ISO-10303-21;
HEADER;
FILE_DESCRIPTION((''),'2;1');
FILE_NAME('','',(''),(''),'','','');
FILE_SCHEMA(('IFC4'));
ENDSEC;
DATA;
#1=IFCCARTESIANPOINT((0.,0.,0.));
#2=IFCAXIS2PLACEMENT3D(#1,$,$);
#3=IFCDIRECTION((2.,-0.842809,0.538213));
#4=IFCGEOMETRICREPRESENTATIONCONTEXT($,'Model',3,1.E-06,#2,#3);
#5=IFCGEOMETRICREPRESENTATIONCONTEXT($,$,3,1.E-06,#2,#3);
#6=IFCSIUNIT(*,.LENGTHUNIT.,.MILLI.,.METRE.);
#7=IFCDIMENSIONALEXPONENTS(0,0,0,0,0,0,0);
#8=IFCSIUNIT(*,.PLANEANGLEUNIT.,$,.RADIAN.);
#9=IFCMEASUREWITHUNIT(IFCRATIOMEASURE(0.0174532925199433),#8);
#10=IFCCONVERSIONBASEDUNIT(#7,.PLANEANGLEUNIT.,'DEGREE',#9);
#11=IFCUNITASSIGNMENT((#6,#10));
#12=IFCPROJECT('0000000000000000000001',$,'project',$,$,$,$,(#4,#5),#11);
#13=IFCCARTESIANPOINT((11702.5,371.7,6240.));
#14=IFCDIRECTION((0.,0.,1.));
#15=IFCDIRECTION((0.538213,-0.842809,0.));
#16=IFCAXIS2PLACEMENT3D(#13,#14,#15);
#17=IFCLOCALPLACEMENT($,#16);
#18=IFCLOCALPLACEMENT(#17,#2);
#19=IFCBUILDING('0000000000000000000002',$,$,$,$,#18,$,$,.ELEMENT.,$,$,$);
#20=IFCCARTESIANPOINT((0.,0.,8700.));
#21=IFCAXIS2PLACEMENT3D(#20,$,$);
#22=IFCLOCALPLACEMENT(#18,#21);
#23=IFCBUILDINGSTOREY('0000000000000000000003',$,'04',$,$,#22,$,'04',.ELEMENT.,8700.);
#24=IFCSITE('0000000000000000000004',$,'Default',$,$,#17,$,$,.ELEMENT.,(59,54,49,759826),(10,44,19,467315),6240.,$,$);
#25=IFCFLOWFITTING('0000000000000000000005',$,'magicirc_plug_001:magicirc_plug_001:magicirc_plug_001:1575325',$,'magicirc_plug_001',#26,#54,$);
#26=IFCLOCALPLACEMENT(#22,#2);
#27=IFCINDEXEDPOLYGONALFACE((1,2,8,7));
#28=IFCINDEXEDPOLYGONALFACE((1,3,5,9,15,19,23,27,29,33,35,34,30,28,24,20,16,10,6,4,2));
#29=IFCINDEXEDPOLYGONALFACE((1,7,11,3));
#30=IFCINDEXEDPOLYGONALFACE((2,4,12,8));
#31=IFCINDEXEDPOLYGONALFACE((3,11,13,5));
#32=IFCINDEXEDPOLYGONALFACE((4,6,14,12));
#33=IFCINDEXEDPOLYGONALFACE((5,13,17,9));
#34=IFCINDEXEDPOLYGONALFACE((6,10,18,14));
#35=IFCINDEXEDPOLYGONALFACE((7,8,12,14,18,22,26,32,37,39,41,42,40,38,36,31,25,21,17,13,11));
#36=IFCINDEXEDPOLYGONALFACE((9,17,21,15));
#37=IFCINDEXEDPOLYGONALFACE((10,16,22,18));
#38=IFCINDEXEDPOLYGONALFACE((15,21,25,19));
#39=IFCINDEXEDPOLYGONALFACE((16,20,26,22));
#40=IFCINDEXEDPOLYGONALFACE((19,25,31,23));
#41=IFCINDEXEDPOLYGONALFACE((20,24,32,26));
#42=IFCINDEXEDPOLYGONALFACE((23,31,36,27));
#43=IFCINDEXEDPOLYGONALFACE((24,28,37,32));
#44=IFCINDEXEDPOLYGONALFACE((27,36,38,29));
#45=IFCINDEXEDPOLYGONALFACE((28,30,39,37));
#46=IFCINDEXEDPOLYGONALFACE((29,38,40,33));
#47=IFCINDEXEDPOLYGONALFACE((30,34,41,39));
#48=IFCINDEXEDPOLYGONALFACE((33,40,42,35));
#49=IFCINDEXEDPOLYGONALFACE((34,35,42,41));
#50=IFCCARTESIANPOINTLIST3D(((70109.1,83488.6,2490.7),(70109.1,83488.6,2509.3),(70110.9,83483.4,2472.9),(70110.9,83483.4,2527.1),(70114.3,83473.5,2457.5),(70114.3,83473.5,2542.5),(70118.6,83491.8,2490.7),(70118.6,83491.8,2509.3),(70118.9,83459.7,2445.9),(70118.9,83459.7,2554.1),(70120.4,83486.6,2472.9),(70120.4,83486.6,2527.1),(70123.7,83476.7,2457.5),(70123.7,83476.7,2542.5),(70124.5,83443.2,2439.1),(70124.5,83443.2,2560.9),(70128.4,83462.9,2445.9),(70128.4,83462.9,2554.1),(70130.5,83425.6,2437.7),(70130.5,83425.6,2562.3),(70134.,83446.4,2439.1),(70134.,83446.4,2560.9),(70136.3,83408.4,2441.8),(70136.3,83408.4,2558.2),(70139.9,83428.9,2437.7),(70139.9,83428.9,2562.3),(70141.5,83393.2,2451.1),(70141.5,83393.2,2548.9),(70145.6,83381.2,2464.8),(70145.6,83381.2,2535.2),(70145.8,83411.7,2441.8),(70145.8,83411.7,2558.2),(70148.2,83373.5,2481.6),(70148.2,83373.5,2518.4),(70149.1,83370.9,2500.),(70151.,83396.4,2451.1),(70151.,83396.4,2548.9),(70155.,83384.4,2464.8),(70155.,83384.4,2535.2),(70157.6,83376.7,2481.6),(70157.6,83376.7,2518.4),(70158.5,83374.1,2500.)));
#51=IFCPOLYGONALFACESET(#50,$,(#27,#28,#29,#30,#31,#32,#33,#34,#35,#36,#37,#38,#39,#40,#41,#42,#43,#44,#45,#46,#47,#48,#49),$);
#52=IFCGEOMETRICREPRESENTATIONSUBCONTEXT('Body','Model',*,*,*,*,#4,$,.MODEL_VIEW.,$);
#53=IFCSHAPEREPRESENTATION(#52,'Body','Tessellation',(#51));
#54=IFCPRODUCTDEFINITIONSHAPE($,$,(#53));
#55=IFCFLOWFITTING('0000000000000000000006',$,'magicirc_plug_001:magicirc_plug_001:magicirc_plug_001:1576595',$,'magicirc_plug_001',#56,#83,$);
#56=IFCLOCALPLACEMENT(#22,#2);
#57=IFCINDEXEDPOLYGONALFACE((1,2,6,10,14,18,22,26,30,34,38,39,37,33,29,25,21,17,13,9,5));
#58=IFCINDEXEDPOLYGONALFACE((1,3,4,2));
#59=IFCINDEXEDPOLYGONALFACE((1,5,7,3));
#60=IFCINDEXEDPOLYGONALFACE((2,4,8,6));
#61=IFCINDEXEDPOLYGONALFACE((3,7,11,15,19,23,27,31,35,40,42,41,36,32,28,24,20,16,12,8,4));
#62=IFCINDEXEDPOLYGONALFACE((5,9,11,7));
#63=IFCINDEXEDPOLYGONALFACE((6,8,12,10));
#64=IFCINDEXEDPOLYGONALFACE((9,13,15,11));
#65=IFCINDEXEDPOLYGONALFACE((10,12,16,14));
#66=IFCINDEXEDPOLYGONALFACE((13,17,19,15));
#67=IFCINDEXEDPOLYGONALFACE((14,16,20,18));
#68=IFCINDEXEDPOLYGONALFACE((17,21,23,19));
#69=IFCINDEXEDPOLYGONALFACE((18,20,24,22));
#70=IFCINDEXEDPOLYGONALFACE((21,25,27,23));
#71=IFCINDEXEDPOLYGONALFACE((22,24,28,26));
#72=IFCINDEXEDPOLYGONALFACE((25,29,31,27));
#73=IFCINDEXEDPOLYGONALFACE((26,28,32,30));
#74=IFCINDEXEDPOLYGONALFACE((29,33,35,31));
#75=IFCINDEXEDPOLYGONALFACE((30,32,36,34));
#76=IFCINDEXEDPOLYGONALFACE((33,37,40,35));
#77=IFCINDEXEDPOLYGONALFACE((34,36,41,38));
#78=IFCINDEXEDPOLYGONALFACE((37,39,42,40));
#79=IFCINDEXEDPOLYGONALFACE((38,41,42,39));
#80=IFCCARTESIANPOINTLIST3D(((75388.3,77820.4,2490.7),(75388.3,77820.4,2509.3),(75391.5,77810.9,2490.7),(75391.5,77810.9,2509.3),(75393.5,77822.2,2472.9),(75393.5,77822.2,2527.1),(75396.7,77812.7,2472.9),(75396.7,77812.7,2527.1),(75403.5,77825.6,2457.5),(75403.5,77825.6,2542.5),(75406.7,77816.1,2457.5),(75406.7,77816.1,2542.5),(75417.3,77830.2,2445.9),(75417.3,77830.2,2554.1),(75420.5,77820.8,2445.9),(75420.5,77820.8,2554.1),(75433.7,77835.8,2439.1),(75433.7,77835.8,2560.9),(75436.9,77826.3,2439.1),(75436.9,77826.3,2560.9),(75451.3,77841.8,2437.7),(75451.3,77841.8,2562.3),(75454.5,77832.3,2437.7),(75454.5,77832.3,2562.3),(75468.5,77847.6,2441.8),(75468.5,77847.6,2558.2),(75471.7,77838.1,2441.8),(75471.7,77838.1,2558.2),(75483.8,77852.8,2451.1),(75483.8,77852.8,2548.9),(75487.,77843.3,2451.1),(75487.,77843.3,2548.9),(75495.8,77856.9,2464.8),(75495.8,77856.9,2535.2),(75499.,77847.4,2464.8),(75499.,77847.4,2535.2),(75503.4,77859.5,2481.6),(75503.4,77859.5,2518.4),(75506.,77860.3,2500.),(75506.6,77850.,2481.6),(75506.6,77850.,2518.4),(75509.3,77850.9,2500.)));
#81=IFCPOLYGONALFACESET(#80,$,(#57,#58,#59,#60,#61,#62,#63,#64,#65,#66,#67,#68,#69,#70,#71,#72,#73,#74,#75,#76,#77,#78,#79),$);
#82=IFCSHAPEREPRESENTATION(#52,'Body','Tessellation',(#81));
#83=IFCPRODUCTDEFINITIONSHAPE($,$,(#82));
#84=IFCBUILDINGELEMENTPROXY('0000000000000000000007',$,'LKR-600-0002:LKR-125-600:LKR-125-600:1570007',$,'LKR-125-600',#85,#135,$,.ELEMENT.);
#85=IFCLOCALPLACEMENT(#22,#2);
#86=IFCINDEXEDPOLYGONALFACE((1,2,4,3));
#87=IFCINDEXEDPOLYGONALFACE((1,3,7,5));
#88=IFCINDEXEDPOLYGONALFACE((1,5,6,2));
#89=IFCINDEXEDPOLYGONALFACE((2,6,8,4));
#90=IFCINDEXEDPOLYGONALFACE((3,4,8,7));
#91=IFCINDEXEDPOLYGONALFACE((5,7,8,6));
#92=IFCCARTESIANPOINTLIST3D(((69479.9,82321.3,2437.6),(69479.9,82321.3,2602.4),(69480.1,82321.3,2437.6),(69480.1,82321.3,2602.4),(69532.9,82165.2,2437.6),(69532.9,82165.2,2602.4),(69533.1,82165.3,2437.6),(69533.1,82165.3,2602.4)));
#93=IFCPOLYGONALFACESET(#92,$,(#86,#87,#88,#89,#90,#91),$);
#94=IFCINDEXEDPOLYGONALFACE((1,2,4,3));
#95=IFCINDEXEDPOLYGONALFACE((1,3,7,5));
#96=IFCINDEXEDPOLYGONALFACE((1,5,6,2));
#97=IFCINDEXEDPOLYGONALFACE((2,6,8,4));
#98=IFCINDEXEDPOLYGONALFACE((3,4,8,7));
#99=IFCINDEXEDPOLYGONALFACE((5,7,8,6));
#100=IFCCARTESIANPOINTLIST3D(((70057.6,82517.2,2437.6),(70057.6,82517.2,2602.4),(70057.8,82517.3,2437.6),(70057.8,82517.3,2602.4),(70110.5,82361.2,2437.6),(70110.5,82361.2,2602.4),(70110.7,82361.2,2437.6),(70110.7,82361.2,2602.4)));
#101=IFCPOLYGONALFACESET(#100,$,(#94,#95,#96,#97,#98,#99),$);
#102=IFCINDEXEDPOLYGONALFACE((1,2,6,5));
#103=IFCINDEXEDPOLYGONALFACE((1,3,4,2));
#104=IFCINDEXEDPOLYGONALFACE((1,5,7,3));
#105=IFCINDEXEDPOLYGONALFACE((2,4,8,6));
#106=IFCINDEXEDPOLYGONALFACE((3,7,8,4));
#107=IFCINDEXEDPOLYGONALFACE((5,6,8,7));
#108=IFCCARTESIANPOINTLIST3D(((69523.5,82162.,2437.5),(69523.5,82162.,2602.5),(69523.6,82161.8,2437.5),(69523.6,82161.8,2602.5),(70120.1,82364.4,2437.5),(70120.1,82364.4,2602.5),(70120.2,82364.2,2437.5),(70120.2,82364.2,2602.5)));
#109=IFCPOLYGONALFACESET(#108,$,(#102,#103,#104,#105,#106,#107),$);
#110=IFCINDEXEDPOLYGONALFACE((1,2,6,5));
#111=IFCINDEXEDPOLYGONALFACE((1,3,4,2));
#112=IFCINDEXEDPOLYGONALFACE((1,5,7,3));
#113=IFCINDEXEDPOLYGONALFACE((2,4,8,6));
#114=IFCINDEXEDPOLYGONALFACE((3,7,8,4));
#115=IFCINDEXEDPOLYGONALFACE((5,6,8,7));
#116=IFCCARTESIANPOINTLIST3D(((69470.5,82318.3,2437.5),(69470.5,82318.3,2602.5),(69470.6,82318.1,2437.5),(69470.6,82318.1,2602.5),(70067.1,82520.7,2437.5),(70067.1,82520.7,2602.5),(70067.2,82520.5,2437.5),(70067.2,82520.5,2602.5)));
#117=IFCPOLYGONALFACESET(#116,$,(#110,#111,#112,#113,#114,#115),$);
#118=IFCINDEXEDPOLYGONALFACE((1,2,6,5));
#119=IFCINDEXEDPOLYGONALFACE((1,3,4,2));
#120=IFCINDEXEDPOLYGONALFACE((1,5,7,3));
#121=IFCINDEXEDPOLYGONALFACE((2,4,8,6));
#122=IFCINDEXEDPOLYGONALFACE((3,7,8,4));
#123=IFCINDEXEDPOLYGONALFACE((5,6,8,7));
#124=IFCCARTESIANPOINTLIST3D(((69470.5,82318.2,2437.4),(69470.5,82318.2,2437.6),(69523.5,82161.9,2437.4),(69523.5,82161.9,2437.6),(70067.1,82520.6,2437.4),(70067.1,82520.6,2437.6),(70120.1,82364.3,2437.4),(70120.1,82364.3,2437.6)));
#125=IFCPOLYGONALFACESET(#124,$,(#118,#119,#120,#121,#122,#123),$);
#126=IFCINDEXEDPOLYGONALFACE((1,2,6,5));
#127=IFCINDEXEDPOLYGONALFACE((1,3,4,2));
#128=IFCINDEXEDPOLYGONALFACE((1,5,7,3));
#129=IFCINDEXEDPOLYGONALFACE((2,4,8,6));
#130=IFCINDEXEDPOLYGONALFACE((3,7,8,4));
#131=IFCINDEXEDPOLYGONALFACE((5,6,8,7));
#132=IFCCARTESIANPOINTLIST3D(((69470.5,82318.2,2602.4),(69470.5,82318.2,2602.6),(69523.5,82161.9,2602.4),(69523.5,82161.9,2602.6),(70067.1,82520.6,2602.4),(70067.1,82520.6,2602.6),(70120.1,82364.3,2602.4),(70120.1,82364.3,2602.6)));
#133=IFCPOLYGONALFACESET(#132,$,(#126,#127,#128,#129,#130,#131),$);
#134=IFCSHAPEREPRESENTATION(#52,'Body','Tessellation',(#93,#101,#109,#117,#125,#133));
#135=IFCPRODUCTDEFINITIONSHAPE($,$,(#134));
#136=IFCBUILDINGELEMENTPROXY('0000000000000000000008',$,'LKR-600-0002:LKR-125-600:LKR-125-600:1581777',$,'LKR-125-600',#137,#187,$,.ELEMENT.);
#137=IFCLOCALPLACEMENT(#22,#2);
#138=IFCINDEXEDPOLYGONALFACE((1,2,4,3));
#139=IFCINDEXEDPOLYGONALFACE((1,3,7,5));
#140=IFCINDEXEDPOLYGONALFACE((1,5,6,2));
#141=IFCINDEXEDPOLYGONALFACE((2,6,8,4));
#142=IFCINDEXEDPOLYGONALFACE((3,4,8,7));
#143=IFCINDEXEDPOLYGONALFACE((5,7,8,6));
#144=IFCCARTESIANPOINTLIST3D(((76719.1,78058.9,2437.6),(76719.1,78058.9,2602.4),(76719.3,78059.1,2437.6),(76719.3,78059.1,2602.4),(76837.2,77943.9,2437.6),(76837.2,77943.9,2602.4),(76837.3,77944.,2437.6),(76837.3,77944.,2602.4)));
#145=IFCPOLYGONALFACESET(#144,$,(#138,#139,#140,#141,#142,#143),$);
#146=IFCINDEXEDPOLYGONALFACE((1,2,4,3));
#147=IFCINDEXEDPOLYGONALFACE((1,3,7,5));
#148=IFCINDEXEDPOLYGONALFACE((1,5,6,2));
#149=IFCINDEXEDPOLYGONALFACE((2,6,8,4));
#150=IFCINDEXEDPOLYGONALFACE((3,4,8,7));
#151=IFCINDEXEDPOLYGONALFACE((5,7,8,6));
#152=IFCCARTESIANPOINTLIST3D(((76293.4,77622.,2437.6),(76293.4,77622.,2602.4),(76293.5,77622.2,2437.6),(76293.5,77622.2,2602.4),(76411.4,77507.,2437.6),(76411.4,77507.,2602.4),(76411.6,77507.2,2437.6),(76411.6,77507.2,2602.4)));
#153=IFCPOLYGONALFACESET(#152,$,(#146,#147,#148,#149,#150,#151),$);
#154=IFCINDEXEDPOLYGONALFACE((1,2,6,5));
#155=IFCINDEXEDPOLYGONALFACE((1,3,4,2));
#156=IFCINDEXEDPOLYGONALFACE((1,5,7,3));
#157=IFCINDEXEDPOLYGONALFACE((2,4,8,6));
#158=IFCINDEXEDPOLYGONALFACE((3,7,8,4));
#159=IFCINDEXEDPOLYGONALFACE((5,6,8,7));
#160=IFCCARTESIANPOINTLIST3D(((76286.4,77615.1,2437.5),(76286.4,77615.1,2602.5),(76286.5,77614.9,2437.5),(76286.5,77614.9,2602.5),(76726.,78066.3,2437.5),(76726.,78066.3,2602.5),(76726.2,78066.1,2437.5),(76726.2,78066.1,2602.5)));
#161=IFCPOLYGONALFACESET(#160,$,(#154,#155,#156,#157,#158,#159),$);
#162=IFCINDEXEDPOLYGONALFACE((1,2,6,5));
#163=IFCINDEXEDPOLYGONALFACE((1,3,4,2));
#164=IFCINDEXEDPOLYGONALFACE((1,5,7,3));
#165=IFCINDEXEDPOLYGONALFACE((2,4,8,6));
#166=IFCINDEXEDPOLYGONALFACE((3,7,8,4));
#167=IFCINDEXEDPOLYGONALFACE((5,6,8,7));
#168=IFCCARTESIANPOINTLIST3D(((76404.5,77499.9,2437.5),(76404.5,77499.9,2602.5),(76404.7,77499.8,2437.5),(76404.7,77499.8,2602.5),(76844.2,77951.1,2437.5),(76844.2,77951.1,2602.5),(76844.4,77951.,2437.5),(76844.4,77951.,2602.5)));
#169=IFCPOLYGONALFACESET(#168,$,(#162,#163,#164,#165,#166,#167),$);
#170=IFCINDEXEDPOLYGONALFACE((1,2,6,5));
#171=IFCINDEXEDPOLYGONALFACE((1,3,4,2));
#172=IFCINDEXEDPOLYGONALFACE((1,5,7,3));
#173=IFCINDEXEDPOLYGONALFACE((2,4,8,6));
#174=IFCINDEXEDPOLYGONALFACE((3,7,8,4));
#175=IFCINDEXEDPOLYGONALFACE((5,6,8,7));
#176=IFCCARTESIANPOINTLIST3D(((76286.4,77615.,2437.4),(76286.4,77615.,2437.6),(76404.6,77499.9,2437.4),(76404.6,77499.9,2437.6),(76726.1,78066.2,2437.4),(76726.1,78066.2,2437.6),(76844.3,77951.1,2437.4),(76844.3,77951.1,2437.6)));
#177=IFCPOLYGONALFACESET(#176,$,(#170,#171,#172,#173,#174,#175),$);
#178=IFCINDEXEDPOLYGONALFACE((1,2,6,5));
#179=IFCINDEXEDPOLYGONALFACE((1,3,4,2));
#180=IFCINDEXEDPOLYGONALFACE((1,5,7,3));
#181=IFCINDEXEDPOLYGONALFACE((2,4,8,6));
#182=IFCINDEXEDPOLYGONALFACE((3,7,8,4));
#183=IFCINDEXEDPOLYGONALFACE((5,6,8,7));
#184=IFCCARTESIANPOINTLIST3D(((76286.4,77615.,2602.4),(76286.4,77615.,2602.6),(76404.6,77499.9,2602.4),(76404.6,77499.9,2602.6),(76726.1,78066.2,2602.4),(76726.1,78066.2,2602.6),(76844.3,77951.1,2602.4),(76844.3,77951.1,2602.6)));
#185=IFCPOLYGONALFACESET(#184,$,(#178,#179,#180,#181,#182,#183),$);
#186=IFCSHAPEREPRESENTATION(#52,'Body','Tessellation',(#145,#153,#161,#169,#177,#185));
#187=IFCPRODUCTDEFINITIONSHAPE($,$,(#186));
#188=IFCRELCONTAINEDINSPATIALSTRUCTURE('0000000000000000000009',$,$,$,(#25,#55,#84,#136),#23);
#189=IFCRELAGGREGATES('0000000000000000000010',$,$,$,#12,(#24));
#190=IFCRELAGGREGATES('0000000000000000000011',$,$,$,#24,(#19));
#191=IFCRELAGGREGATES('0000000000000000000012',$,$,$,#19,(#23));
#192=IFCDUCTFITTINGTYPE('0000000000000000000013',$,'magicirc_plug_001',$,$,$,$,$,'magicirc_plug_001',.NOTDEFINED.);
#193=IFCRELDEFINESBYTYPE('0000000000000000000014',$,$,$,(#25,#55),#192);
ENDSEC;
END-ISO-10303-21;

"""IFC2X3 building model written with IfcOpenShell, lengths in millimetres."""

from ifc_helpers import new_model, entity, si_unit, converted_unit, direction, frame, frame_2d, origin, place, context, subcontext, project, spatial, rectangle, circle, extrude, source, transform, mapped, type_object, type_shapes, element, save


model = new_model("IFC2X3")

# Units and contexts
model_context = context("Model", 3, precision=1e-06, world=origin(), true_north=direction((2.0, -0.842809, 0.538213)))
context_of_model = context(None, 3, precision=1e-06, world=origin(), true_north=direction((2.0, -0.842809, 0.538213)))
body_context = subcontext(model_context, "Body", "Model", "MODEL_VIEW")
ifc_project = project(units=[si_unit("LENGTHUNIT", "METRE", prefix="MILLI"), converted_unit("PLANEANGLEUNIT", "DEGREE", entity("IfcRatioMeasure", 0.0174532925199433), si_unit("PLANEANGLEUNIT", "RADIAN"), dimensions=[0, 0, 0, 0, 0, 0, 0])], contexts=[model_context, context_of_model])

# Site, building, storey
site_placement = place(None, frame((11702.5, 371.7, 6240.0), z_axis=(0.0, 0.0, 1.0), x_axis=(0.538213, -0.842809, 0.0)))
site = spatial("IfcSite", under=ifc_project, at=site_placement, Name="Default", CompositionType="ELEMENT", RefLatitude=(59, 54, 49, 759826), RefLongitude=(10, 44, 19, 467315), RefElevation=6240.0)
building_placement = place(site_placement, origin())
building = spatial("IfcBuilding", under=site, at=building_placement, CompositionType="ELEMENT")
storey_placement = place(building_placement, frame((0.0, 0.0, 8700.0)))
storey = spatial("IfcBuildingStorey", under=building, at=storey_placement, Name="04", LongName="04", CompositionType="ELEMENT", Elevation=8700.0)

# Flow fittings
duct_fitting_type_1 = type_object("IfcDuctFittingType", Name="magicirc_plug_001", ElementType="magicirc_plug_001", PredefinedType="NOTDEFINED")
shared_shape_1 = source(origin(), body_context, "Body", "SweptSolid", [
    extrude(circle(Radius=62.5, at=frame_2d((0.0, 0.0), x_axis=(1.0, 0.0))), frame((0.0, 0.0, 0.0), z_axis=(1.0, 0.0, 0.0), x_axis=(0.0, 1.0, 0.0)), (0.0, 0.0, 1.0), 10.0),
])
type_shapes(duct_fitting_type_1, [shared_shape_1])
for number, where, z_axis, x_axis, name in (
    (1, (70138.4, 83433.3, 2500.0), (0.0, 0.0, 1.0), (-0.946986, -0.321274, 0.0), "magicirc_plug_001:magicirc_plug_001:magicirc_plug_001:1575325"),
    (2, (75446.9, 77840.3, 2500.0), (0.0, 0.0, 1.0), (0.321274, -0.946986, 0.0), "magicirc_plug_001:magicirc_plug_001:magicirc_plug_001:1576595"),
):
    element("IfcFlowFitting", number, at=place(storey_placement, frame(where, z_axis=z_axis, x_axis=x_axis)), inside=storey, type_object=duct_fitting_type_1, Name=name, ObjectType="magicirc_plug_001", context=body_context, shape_type="MappedRepresentation", body=[
        mapped(shared_shape_1, transform((0.0, 0.0, 0.0), scale=1.0)),
    ])

# Building element proxies
shared_shape_2 = source(origin(), body_context, "Body", "SweptSolid", [
    extrude(rectangle(XDim=0.2, YDim=164.8, at=frame_2d((0.0, 0.0), x_axis=(1.0, 0.0))), frame((305.0, 0.0, -82.4)), (0.0, 0.0, 1.0), 164.8),
    extrude(rectangle(XDim=0.2, YDim=164.8, at=frame_2d((0.0, 0.0), x_axis=(1.0, 0.0))), frame((-305.0, 0.0, -82.4)), (0.0, 0.0, 1.0), 164.8),
    extrude(rectangle(XDim=0.2, YDim=630.0, at=frame_2d((0.0, 0.0), x_axis=(1.0, 0.0))), frame((0.0, 82.5, -82.5), z_axis=(0.0, 0.0, 1.0), x_axis=(0.0, 1.0, 0.0)), (0.0, 0.0, 1.0), 165.0),
    extrude(rectangle(XDim=0.2, YDim=630.0, at=frame_2d((0.0, 0.0), x_axis=(1.0, 0.0))), frame((0.0, -82.5, -82.5), z_axis=(0.0, 0.0, 1.0), x_axis=(0.0, 1.0, 0.0)), (0.0, 0.0, 1.0), 165.0),
    extrude(rectangle(XDim=165.0, YDim=630.0, at=frame_2d((0.0, 0.0), x_axis=(1.0, 0.0))), frame((0.0, 0.0, -82.6), z_axis=(0.0, 0.0, 1.0), x_axis=(0.0, -1.0, 0.0)), (0.0, 0.0, 1.0), 0.2),
    extrude(rectangle(XDim=165.0, YDim=630.0, at=frame_2d((0.0, 0.0), x_axis=(1.0, 0.0))), frame((0.0, 0.0, 82.4), z_axis=(0.0, 0.0, 1.0), x_axis=(0.0, -1.0, 0.0)), (0.0, 0.0, 1.0), 0.2),
])
for number, where, z_axis, x_axis, name in (
    (3, (69795.3, 82341.3, 2520.0), (0.0, 0.0, 1.0), (-0.946986, -0.321274, 0.0), "LKR-600-0002:LKR-125-600:LKR-125-600:1570007"),
    (4, (76565.4, 77783.0, 2520.0), (0.0, 0.0, 1.0), (0.697915, 0.71618, 0.0), "LKR-600-0002:LKR-125-600:LKR-125-600:1581777"),
):
    element("IfcBuildingElementProxy", number, at=place(storey_placement, frame(where, z_axis=z_axis, x_axis=x_axis)), inside=storey, Name=name, ObjectType="LKR-125-600", CompositionType="ELEMENT", context=body_context, shape_type="MappedRepresentation", body=[
        mapped(shared_shape_2, transform((0.0, 0.0, 0.0), scale=1.0)),
    ])

save(model, "model.ifc")
